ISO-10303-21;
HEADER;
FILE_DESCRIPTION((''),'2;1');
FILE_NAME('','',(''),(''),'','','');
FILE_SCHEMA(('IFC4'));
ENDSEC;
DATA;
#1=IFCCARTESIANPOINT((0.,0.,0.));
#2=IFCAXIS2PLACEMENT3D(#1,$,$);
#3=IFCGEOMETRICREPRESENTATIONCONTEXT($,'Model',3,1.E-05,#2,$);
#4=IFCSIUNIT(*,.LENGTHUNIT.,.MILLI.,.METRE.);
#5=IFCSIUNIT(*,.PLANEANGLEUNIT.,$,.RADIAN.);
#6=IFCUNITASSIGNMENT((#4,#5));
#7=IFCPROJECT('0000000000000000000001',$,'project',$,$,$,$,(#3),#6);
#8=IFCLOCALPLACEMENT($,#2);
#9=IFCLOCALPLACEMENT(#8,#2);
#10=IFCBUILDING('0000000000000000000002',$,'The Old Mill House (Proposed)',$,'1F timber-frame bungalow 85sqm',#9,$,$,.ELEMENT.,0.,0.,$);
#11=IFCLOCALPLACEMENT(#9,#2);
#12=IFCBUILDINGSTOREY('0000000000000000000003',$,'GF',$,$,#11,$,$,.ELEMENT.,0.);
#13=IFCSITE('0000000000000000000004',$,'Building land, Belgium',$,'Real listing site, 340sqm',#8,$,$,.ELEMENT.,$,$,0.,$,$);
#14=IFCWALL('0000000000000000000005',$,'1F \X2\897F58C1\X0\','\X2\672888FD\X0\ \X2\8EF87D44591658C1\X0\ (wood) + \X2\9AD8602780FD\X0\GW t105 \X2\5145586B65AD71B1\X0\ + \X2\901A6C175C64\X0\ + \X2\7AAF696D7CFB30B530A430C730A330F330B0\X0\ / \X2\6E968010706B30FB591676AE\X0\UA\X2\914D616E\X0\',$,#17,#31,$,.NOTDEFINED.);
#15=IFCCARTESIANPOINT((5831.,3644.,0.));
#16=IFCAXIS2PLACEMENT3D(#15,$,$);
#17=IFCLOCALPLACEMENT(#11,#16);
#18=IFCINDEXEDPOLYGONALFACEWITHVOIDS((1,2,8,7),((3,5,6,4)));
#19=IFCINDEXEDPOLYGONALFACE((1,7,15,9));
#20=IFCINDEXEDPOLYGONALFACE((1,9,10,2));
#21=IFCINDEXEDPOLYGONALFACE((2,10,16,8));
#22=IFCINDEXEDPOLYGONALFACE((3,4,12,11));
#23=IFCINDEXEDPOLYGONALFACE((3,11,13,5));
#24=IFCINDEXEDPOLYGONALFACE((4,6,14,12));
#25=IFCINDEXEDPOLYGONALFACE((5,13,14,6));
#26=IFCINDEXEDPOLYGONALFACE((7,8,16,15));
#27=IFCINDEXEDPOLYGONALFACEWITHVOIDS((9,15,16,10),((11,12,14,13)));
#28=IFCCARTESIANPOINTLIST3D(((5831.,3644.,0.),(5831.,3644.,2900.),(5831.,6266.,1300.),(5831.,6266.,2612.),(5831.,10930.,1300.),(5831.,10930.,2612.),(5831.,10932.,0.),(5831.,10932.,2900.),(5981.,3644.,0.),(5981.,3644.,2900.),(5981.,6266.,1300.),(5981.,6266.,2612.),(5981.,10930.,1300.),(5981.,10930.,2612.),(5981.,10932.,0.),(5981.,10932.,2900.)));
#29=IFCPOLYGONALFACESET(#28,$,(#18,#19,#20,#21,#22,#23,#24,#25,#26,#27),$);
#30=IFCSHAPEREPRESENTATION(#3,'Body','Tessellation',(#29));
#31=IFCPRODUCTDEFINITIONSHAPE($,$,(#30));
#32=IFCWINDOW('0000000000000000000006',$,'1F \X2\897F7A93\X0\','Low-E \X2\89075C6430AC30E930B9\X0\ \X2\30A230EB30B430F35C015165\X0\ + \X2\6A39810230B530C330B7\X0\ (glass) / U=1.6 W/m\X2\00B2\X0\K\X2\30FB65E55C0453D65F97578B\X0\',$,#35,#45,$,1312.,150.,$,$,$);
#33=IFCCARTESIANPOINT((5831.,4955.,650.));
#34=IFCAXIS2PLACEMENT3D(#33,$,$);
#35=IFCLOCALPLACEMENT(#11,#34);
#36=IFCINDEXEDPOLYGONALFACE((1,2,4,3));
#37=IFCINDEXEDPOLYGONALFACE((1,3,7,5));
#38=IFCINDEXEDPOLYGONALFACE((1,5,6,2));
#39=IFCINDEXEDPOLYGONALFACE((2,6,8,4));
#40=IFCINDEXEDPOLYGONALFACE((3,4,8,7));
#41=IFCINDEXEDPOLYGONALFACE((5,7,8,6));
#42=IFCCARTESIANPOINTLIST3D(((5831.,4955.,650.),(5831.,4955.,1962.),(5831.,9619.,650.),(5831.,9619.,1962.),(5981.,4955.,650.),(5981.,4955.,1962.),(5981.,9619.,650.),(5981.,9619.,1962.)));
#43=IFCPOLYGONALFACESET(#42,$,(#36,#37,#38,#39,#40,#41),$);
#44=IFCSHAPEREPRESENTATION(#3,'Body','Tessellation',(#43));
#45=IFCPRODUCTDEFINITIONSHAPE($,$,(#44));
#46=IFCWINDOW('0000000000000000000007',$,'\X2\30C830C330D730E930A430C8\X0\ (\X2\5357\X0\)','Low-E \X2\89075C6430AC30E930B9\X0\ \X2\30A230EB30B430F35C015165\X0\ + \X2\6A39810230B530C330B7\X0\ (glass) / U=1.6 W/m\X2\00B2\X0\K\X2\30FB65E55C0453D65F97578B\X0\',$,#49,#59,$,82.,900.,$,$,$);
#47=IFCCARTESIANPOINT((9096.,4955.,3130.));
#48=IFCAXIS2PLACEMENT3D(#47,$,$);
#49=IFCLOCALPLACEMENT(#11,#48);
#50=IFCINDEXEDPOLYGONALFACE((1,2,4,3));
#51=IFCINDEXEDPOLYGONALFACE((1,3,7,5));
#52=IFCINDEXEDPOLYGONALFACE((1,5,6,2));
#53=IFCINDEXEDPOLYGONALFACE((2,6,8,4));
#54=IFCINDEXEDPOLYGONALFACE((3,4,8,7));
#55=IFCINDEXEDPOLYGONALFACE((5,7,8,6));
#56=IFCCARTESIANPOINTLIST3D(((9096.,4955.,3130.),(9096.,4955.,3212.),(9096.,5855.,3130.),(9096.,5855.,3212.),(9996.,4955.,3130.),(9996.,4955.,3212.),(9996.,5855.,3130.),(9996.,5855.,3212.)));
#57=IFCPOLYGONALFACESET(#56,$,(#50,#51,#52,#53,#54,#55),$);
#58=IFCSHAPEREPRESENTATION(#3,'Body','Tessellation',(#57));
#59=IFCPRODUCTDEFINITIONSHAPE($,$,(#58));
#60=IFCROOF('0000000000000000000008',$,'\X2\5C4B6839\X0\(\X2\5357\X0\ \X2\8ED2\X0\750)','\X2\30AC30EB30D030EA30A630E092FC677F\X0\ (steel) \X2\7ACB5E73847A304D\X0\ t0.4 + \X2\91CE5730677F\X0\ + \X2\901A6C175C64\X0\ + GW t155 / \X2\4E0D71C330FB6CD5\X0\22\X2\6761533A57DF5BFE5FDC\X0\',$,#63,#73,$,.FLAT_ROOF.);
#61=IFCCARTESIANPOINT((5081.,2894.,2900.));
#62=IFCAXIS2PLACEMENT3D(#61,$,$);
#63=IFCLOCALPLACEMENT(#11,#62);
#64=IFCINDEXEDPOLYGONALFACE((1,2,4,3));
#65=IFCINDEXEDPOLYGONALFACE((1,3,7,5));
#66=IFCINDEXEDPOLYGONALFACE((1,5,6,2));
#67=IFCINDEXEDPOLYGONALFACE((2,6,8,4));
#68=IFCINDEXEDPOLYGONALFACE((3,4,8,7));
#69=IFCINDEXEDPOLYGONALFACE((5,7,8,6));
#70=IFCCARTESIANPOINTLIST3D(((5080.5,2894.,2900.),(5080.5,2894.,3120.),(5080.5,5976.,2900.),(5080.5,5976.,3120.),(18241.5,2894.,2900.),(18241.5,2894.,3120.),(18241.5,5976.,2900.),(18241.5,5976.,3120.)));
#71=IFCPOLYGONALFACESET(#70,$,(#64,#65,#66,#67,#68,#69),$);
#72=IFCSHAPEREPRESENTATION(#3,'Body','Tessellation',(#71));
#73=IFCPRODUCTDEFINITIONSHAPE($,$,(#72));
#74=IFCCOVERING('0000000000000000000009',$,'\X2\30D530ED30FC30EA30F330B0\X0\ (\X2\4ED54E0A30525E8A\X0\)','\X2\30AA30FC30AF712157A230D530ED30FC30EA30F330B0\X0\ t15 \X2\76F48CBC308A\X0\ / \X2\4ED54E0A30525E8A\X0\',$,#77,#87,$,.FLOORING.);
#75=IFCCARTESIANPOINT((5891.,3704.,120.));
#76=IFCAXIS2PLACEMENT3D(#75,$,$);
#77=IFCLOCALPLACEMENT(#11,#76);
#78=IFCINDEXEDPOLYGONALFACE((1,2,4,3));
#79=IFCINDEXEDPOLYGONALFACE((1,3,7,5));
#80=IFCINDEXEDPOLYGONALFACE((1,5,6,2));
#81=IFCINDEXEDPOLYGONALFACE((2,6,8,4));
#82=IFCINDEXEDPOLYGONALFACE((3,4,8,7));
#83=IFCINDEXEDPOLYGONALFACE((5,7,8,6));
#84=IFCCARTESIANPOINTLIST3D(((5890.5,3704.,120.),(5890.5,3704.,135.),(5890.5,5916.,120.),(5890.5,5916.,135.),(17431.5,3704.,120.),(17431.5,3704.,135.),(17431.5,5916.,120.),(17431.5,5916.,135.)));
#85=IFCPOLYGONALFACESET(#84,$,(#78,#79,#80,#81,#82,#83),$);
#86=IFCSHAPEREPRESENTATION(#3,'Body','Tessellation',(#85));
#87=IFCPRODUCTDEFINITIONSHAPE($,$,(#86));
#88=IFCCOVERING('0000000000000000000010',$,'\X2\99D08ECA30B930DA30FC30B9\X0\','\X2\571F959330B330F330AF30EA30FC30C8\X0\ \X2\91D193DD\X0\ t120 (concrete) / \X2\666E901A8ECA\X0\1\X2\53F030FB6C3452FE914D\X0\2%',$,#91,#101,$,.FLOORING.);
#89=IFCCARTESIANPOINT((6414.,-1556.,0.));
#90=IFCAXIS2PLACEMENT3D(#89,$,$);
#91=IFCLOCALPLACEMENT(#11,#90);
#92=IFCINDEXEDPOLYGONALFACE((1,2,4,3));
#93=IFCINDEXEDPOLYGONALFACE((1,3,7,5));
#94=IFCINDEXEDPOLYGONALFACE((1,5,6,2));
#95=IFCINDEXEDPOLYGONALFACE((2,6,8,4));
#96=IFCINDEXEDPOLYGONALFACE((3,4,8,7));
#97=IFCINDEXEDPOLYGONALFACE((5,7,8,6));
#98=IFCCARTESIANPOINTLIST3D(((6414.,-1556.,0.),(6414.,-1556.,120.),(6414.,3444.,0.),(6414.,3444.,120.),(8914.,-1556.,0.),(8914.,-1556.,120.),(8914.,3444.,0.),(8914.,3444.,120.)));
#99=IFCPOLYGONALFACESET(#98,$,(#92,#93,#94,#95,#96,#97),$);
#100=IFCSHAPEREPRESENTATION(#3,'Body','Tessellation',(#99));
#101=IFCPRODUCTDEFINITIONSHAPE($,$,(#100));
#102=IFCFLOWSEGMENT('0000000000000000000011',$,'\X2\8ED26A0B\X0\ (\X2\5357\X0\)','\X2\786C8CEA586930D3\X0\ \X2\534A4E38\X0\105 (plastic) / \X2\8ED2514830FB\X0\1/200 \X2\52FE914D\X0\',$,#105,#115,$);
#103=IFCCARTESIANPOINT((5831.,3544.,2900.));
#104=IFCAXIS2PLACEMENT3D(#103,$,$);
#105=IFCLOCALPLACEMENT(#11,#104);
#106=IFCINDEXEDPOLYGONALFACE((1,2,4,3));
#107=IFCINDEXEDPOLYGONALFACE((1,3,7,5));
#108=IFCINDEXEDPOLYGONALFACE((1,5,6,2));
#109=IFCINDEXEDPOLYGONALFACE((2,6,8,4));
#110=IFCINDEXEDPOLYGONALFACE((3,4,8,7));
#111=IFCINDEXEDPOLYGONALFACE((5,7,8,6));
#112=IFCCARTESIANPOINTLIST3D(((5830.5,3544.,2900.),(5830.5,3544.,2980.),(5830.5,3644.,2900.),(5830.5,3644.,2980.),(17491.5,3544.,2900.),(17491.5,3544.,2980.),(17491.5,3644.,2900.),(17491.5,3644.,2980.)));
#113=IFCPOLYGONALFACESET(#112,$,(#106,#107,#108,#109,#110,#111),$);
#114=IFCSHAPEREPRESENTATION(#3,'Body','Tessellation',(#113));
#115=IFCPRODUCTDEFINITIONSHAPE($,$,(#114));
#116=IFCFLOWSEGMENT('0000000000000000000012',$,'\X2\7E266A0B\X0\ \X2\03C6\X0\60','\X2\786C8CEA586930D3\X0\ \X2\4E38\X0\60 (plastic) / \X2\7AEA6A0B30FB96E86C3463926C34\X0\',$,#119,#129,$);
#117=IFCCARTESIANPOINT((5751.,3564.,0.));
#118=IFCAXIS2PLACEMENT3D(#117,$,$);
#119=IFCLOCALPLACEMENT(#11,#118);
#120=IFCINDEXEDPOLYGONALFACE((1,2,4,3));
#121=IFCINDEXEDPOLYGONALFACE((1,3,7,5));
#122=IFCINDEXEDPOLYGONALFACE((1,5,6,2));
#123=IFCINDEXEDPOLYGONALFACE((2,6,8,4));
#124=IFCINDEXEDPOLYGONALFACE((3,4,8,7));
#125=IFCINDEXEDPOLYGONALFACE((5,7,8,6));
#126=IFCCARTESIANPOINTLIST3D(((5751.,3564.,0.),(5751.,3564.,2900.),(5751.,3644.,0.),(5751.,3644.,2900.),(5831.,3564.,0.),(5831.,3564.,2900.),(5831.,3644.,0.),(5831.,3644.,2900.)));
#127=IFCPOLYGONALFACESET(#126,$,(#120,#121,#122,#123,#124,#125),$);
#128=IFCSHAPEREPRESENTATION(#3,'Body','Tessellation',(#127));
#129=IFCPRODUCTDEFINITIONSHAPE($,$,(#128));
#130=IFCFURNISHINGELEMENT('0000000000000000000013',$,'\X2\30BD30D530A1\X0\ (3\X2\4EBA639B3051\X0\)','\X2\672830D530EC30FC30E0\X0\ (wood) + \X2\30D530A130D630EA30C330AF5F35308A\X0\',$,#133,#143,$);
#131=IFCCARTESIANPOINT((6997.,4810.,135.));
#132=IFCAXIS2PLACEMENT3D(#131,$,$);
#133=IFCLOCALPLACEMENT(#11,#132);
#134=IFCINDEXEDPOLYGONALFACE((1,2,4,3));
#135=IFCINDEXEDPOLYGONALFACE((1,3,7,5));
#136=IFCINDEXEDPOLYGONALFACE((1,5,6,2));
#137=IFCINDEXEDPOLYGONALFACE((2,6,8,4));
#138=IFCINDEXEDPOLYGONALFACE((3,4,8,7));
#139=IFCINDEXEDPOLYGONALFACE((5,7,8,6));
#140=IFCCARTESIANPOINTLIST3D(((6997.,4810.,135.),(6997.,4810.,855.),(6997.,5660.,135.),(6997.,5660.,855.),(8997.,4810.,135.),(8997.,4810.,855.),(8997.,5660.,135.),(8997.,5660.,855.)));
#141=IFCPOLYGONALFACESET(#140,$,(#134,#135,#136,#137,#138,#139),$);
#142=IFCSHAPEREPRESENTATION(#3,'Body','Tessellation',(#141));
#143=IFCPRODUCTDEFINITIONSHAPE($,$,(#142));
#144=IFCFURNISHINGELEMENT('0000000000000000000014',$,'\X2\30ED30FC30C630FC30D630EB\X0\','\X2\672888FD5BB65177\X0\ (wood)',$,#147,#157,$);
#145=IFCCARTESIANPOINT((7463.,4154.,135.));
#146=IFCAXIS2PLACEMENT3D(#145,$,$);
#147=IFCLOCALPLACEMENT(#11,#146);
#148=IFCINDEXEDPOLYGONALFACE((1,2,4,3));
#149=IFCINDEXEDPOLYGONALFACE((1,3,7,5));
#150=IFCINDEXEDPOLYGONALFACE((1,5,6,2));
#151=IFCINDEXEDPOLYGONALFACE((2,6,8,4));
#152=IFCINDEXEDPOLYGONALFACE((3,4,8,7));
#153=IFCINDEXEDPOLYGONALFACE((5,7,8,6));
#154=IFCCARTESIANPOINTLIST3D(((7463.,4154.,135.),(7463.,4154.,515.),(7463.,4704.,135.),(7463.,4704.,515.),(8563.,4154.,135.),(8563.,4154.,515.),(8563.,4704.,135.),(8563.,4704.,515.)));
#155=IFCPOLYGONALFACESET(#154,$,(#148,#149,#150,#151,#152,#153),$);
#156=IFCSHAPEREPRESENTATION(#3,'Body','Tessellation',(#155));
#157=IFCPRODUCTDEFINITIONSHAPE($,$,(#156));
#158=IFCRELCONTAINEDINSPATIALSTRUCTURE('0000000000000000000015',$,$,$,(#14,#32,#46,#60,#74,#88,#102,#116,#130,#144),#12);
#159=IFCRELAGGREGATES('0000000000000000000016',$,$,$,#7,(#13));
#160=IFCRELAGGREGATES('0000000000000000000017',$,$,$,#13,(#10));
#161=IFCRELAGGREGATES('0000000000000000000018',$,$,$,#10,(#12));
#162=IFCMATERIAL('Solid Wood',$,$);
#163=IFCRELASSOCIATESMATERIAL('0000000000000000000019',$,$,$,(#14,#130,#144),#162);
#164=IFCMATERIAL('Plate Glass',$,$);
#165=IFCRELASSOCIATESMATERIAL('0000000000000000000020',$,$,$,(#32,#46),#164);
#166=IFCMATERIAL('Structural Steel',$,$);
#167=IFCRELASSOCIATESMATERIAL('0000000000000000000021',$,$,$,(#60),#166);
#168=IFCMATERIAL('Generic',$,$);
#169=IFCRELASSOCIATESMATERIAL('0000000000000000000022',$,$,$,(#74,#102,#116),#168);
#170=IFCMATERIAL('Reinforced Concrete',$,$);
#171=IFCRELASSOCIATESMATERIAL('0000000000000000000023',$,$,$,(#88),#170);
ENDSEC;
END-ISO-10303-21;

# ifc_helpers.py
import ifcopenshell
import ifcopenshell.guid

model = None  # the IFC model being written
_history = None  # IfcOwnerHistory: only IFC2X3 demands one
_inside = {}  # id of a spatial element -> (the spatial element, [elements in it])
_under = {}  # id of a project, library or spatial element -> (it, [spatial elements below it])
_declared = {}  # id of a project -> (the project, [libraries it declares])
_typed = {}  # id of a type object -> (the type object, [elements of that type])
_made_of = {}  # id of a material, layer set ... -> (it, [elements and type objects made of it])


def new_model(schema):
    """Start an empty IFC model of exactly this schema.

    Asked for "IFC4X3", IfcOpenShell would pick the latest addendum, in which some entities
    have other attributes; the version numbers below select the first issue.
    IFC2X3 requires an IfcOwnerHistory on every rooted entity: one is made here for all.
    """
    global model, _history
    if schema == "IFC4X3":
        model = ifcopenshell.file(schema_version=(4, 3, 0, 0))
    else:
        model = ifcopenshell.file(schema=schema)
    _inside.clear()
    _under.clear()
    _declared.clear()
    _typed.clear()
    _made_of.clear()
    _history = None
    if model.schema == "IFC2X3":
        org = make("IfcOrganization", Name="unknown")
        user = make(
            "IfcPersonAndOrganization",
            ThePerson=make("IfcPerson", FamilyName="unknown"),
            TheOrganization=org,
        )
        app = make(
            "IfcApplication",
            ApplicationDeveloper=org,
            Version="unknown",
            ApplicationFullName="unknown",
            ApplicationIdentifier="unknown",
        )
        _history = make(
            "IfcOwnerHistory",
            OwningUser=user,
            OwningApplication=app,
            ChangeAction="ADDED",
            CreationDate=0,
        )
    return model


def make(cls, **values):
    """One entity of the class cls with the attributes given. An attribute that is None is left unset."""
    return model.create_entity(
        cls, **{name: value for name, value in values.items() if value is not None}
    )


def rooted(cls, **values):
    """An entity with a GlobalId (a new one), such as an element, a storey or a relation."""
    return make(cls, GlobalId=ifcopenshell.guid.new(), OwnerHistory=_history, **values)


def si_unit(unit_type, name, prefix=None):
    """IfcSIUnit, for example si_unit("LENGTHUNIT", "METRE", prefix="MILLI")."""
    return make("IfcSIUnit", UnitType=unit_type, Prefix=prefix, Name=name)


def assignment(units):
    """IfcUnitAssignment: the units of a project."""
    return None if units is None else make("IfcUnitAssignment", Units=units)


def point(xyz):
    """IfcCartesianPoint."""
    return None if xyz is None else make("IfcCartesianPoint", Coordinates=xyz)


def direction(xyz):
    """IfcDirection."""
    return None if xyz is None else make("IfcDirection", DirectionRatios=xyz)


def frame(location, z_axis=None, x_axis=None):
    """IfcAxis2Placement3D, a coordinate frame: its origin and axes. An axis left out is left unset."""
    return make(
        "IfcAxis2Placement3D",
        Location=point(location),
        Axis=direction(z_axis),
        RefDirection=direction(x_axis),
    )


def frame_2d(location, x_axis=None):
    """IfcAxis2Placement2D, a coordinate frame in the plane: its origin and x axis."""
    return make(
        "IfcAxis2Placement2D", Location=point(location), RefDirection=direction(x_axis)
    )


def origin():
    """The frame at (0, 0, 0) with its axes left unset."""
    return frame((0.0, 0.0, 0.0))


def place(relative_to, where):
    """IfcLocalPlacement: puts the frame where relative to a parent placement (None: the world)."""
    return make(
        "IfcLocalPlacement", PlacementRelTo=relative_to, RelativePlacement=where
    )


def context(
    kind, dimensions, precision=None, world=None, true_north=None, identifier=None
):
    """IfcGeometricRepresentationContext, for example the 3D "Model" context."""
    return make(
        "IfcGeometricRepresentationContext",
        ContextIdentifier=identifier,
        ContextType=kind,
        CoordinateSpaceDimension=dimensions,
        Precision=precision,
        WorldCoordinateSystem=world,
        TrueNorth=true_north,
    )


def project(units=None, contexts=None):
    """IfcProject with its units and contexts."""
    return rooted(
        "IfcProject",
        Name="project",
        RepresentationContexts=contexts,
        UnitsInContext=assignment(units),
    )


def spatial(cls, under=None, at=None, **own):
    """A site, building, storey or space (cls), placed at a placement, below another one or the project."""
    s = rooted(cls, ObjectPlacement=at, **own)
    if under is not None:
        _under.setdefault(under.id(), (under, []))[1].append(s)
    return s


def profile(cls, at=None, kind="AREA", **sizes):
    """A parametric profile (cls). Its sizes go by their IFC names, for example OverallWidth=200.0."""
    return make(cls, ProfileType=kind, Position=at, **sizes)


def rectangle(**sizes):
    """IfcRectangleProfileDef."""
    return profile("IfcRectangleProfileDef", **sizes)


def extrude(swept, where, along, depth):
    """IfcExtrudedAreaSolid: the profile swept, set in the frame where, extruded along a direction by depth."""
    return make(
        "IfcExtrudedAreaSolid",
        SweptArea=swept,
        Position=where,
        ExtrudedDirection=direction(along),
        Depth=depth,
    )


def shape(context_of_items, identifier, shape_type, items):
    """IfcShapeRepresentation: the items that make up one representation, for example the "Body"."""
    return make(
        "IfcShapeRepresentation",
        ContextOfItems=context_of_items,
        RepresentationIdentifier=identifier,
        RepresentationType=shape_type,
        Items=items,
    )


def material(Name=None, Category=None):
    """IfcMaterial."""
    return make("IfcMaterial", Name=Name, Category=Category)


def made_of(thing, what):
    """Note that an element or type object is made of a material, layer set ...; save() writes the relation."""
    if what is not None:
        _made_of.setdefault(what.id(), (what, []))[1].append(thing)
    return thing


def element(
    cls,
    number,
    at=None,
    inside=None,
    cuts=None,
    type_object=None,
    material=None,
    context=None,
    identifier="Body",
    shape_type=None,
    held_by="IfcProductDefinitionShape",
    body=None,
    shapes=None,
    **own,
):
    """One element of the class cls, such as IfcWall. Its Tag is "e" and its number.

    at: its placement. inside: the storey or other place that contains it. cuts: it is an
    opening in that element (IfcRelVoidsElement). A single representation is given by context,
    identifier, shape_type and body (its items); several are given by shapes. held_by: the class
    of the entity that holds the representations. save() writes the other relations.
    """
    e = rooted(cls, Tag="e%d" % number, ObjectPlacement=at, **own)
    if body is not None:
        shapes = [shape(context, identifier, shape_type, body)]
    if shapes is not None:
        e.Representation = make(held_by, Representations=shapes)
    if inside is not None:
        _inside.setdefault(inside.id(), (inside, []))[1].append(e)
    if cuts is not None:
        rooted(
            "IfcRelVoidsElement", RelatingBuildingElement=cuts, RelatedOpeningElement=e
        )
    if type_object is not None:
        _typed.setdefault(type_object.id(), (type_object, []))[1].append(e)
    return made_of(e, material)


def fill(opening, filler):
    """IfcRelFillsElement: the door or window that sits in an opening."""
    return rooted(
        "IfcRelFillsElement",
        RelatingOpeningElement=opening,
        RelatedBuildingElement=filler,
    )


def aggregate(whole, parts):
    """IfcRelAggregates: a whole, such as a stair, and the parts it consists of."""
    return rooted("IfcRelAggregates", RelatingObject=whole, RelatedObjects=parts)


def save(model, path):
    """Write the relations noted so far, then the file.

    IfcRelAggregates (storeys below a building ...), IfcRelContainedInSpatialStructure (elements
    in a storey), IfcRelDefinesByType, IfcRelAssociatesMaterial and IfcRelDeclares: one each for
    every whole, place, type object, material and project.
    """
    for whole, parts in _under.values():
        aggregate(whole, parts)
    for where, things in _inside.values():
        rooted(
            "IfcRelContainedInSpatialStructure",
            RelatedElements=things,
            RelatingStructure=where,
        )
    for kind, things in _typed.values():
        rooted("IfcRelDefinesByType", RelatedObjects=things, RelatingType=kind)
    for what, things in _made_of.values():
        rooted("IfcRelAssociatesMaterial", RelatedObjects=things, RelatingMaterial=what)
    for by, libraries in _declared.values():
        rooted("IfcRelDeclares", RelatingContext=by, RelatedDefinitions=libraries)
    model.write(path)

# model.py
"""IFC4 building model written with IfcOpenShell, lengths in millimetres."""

from ifc_helpers import new_model, si_unit, frame, frame_2d, origin, place, context, project, spatial, rectangle, extrude, material, element, fill, save


model = new_model("IFC4")

# Units and contexts
model_context = context("Model", 3, precision=1e-05, world=origin())
ifc_project = project(units=[si_unit("LENGTHUNIT", "METRE", prefix="MILLI"), si_unit("PLANEANGLEUNIT", "RADIAN")], contexts=[model_context])

# Site, building, storey
site_placement = place(None, origin())
site = spatial("IfcSite", under=ifc_project, at=site_placement, Name="Building land, Belgium", ObjectType="Real listing site, 340sqm", CompositionType="ELEMENT", RefElevation=0.0)
building_placement = place(site_placement, origin())
building = spatial("IfcBuilding", under=site, at=building_placement, Name="The Old Mill House (Proposed)", ObjectType="1F timber-frame bungalow 85sqm", CompositionType="ELEMENT", ElevationOfRefHeight=0.0, ElevationOfTerrain=0.0)
storey_placement = place(building_placement, origin())
storey = spatial("IfcBuildingStorey", under=building, at=storey_placement, Name="GF", CompositionType="ELEMENT", Elevation=0.0)

# Shared definitions
ifc_material_1 = material(Name="Solid Wood")

# Shared definitions
ifc_material_2 = material(Name="Reinforced Concrete")

# Shared definitions
ifc_material_3 = material(Name="Plate Glass")

# Wall, opening, window
wall_1_placement = place(storey_placement, frame((5831.0, 3644.0, 0.0)))
wall_1 = element("IfcWall", 1, at=wall_1_placement, inside=storey, material=ifc_material_1, Name="1F 西壁", Description="木製 軸組外壁 (wood) + 高性能GW t105 充填断熱 + 通気層 + 窯業系サイディング / 準耐火・外皮UA配慮", PredefinedType="NOTDEFINED", context=model_context, shape_type="SweptSolid", body=[
    extrude(rectangle(XDim=150.0, YDim=7288.0, at=frame_2d((75.0, 3644.0))), frame((5831.0, 3644.0, 0.0)), (0.0, 0.0, 1.0), 2900.0),
])
opening_1_placement = place(storey_placement, frame((5831.0, 4955.0, 650.0)))
opening_1 = element("IfcOpeningElement", 2, at=opening_1_placement, cuts=wall_1, PredefinedType="NOTDEFINED", context=model_context, shape_type="SweptSolid", body=[
    extrude(rectangle(XDim=150.0, YDim=4664.0, at=frame_2d((75.0, 2332.0))), frame((5831.0, 4955.0, 650.0)), (0.0, 0.0, 1.0), 1312.0),
])
window_1_placement = place(storey_placement, frame((5831.0, 4955.0, 650.0)))
window_1 = element("IfcWindow", 3, at=window_1_placement, inside=storey, material=ifc_material_3, Name="1F 西窓", Description="Low-E 複層ガラス アルゴン封入 + 樹脂サッシ (glass) / U=1.6 W/m²K・日射取得型", OverallHeight=1312.0, OverallWidth=150.0, context=model_context, shape_type="SweptSolid", body=[
    extrude(rectangle(XDim=150.0, YDim=4664.0, at=frame_2d((75.0, 2332.0))), frame((5831.0, 4955.0, 650.0)), (0.0, 0.0, 1.0), 1312.0),
])
fill(opening_1, window_1)

# Window
window_2_placement = place(storey_placement, frame((9096.0, 4955.0, 3130.0)))
element("IfcWindow", 4, at=window_2_placement, inside=storey, material=ifc_material_3, Name="トップライト (南)", Description="Low-E 複層ガラス アルゴン封入 + 樹脂サッシ (glass) / U=1.6 W/m²K・日射取得型", OverallHeight=82.0, OverallWidth=900.0, context=model_context, shape_type="SweptSolid", body=[
    extrude(rectangle(XDim=900.0, YDim=900.0, at=frame_2d((450.0, 450.0))), frame((9096.0, 4955.0, 3130.0)), (0.0, 0.0, 1.0), 82.0),
])

# Roof
ifc_material_4 = material(Name="Structural Steel")
roof_1_placement = place(storey_placement, frame((5081.0, 2894.0, 2900.0)))
element("IfcRoof", 5, at=roof_1_placement, inside=storey, material=ifc_material_4, Name="屋根(南 軒750)", Description="ガルバリウム鋼板 (steel) 立平葺き t0.4 + 野地板 + 通気層 + GW t155 / 不燃・法22条区域対応", PredefinedType="FLAT_ROOF", context=model_context, shape_type="SweptSolid", body=[
    extrude(rectangle(XDim=13161.0, YDim=3082.0, at=frame_2d((6580.0, 1541.0))), frame((5081.0, 2894.0, 2900.0)), (0.0, 0.0, 1.0), 220.0),
])

# Coverings
ifc_material_5 = material(Name="Generic")
covering_1_placement = place(storey_placement, frame((5891.0, 3704.0, 120.0)))
element("IfcCovering", 6, at=covering_1_placement, inside=storey, material=ifc_material_5, Name="フローリング (仕上げ床)", Description="オーク無垢フローリング t15 直貼り / 仕上げ床", PredefinedType="FLOORING", context=model_context, shape_type="SweptSolid", body=[
    extrude(rectangle(XDim=11541.0, YDim=2212.0, at=frame_2d((5770.0, 1106.0))), frame((5891.0, 3704.0, 120.0)), (0.0, 0.0, 1.0), 15.0),
])
covering_2_placement = place(storey_placement, frame((6414.0, -1556.0, 0.0)))
element("IfcCovering", 7, at=covering_2_placement, inside=storey, material=ifc_material_2, Name="駐車スペース", Description="土間コンクリート 金鏝 t120 (concrete) / 普通車1台・水勾配2%", PredefinedType="FLOORING", context=model_context, shape_type="SweptSolid", body=[
    extrude(rectangle(XDim=2500.0, YDim=5000.0, at=frame_2d((1250.0, 2500.0))), frame((6414.0, -1556.0, 0.0)), (0.0, 0.0, 1.0), 120.0),
])

# Flow segments
flow_segment_1_placement = place(storey_placement, frame((5831.0, 3544.0, 2900.0)))
element("IfcFlowSegment", 8, at=flow_segment_1_placement, inside=storey, material=ifc_material_5, Name="軒樋 (南)", Description="硬質塩ビ 半丸105 (plastic) / 軒先・1/200 勾配", context=model_context, shape_type="SweptSolid", body=[
    extrude(rectangle(XDim=11661.0, YDim=100.0, at=frame_2d((5830.0, 50.0))), frame((5831.0, 3544.0, 2900.0)), (0.0, 0.0, 1.0), 80.0),
])
flow_segment_2_placement = place(storey_placement, frame((5751.0, 3564.0, 0.0)))
element("IfcFlowSegment", 9, at=flow_segment_2_placement, inside=storey, material=ifc_material_5, Name="縦樋 φ60", Description="硬質塩ビ 丸60 (plastic) / 竪樋・雨水排水", context=model_context, shape_type="SweptSolid", body=[
    extrude(rectangle(XDim=80.0, YDim=80.0, at=frame_2d((40.0, 40.0))), frame((5751.0, 3564.0, 0.0)), (0.0, 0.0, 1.0), 2900.0),
])

# Furnishing elements
furnishing_1_placement = place(storey_placement, frame((6997.0, 4810.0, 135.0)))
element("IfcFurnishingElement", 10, at=furnishing_1_placement, inside=storey, material=ifc_material_1, Name="ソファ (3人掛け)", Description="木フレーム (wood) + ファブリック張り", context=model_context, shape_type="SweptSolid", body=[
    extrude(rectangle(XDim=2000.0, YDim=850.0, at=frame_2d((1000.0, 425.0))), frame((6997.0, 4810.0, 135.0)), (0.0, 0.0, 1.0), 720.0),
])
furnishing_2_placement = place(storey_placement, frame((7463.0, 4154.0, 135.0)))
element("IfcFurnishingElement", 11, at=furnishing_2_placement, inside=storey, material=ifc_material_1, Name="ローテーブル", Description="木製家具 (wood)", context=model_context, shape_type="SweptSolid", body=[
    extrude(rectangle(XDim=1100.0, YDim=550.0, at=frame_2d((550.0, 275.0))), frame((7463.0, 4154.0, 135.0)), (0.0, 0.0, 1.0), 380.0),
])

save(model, "model.ifc")
